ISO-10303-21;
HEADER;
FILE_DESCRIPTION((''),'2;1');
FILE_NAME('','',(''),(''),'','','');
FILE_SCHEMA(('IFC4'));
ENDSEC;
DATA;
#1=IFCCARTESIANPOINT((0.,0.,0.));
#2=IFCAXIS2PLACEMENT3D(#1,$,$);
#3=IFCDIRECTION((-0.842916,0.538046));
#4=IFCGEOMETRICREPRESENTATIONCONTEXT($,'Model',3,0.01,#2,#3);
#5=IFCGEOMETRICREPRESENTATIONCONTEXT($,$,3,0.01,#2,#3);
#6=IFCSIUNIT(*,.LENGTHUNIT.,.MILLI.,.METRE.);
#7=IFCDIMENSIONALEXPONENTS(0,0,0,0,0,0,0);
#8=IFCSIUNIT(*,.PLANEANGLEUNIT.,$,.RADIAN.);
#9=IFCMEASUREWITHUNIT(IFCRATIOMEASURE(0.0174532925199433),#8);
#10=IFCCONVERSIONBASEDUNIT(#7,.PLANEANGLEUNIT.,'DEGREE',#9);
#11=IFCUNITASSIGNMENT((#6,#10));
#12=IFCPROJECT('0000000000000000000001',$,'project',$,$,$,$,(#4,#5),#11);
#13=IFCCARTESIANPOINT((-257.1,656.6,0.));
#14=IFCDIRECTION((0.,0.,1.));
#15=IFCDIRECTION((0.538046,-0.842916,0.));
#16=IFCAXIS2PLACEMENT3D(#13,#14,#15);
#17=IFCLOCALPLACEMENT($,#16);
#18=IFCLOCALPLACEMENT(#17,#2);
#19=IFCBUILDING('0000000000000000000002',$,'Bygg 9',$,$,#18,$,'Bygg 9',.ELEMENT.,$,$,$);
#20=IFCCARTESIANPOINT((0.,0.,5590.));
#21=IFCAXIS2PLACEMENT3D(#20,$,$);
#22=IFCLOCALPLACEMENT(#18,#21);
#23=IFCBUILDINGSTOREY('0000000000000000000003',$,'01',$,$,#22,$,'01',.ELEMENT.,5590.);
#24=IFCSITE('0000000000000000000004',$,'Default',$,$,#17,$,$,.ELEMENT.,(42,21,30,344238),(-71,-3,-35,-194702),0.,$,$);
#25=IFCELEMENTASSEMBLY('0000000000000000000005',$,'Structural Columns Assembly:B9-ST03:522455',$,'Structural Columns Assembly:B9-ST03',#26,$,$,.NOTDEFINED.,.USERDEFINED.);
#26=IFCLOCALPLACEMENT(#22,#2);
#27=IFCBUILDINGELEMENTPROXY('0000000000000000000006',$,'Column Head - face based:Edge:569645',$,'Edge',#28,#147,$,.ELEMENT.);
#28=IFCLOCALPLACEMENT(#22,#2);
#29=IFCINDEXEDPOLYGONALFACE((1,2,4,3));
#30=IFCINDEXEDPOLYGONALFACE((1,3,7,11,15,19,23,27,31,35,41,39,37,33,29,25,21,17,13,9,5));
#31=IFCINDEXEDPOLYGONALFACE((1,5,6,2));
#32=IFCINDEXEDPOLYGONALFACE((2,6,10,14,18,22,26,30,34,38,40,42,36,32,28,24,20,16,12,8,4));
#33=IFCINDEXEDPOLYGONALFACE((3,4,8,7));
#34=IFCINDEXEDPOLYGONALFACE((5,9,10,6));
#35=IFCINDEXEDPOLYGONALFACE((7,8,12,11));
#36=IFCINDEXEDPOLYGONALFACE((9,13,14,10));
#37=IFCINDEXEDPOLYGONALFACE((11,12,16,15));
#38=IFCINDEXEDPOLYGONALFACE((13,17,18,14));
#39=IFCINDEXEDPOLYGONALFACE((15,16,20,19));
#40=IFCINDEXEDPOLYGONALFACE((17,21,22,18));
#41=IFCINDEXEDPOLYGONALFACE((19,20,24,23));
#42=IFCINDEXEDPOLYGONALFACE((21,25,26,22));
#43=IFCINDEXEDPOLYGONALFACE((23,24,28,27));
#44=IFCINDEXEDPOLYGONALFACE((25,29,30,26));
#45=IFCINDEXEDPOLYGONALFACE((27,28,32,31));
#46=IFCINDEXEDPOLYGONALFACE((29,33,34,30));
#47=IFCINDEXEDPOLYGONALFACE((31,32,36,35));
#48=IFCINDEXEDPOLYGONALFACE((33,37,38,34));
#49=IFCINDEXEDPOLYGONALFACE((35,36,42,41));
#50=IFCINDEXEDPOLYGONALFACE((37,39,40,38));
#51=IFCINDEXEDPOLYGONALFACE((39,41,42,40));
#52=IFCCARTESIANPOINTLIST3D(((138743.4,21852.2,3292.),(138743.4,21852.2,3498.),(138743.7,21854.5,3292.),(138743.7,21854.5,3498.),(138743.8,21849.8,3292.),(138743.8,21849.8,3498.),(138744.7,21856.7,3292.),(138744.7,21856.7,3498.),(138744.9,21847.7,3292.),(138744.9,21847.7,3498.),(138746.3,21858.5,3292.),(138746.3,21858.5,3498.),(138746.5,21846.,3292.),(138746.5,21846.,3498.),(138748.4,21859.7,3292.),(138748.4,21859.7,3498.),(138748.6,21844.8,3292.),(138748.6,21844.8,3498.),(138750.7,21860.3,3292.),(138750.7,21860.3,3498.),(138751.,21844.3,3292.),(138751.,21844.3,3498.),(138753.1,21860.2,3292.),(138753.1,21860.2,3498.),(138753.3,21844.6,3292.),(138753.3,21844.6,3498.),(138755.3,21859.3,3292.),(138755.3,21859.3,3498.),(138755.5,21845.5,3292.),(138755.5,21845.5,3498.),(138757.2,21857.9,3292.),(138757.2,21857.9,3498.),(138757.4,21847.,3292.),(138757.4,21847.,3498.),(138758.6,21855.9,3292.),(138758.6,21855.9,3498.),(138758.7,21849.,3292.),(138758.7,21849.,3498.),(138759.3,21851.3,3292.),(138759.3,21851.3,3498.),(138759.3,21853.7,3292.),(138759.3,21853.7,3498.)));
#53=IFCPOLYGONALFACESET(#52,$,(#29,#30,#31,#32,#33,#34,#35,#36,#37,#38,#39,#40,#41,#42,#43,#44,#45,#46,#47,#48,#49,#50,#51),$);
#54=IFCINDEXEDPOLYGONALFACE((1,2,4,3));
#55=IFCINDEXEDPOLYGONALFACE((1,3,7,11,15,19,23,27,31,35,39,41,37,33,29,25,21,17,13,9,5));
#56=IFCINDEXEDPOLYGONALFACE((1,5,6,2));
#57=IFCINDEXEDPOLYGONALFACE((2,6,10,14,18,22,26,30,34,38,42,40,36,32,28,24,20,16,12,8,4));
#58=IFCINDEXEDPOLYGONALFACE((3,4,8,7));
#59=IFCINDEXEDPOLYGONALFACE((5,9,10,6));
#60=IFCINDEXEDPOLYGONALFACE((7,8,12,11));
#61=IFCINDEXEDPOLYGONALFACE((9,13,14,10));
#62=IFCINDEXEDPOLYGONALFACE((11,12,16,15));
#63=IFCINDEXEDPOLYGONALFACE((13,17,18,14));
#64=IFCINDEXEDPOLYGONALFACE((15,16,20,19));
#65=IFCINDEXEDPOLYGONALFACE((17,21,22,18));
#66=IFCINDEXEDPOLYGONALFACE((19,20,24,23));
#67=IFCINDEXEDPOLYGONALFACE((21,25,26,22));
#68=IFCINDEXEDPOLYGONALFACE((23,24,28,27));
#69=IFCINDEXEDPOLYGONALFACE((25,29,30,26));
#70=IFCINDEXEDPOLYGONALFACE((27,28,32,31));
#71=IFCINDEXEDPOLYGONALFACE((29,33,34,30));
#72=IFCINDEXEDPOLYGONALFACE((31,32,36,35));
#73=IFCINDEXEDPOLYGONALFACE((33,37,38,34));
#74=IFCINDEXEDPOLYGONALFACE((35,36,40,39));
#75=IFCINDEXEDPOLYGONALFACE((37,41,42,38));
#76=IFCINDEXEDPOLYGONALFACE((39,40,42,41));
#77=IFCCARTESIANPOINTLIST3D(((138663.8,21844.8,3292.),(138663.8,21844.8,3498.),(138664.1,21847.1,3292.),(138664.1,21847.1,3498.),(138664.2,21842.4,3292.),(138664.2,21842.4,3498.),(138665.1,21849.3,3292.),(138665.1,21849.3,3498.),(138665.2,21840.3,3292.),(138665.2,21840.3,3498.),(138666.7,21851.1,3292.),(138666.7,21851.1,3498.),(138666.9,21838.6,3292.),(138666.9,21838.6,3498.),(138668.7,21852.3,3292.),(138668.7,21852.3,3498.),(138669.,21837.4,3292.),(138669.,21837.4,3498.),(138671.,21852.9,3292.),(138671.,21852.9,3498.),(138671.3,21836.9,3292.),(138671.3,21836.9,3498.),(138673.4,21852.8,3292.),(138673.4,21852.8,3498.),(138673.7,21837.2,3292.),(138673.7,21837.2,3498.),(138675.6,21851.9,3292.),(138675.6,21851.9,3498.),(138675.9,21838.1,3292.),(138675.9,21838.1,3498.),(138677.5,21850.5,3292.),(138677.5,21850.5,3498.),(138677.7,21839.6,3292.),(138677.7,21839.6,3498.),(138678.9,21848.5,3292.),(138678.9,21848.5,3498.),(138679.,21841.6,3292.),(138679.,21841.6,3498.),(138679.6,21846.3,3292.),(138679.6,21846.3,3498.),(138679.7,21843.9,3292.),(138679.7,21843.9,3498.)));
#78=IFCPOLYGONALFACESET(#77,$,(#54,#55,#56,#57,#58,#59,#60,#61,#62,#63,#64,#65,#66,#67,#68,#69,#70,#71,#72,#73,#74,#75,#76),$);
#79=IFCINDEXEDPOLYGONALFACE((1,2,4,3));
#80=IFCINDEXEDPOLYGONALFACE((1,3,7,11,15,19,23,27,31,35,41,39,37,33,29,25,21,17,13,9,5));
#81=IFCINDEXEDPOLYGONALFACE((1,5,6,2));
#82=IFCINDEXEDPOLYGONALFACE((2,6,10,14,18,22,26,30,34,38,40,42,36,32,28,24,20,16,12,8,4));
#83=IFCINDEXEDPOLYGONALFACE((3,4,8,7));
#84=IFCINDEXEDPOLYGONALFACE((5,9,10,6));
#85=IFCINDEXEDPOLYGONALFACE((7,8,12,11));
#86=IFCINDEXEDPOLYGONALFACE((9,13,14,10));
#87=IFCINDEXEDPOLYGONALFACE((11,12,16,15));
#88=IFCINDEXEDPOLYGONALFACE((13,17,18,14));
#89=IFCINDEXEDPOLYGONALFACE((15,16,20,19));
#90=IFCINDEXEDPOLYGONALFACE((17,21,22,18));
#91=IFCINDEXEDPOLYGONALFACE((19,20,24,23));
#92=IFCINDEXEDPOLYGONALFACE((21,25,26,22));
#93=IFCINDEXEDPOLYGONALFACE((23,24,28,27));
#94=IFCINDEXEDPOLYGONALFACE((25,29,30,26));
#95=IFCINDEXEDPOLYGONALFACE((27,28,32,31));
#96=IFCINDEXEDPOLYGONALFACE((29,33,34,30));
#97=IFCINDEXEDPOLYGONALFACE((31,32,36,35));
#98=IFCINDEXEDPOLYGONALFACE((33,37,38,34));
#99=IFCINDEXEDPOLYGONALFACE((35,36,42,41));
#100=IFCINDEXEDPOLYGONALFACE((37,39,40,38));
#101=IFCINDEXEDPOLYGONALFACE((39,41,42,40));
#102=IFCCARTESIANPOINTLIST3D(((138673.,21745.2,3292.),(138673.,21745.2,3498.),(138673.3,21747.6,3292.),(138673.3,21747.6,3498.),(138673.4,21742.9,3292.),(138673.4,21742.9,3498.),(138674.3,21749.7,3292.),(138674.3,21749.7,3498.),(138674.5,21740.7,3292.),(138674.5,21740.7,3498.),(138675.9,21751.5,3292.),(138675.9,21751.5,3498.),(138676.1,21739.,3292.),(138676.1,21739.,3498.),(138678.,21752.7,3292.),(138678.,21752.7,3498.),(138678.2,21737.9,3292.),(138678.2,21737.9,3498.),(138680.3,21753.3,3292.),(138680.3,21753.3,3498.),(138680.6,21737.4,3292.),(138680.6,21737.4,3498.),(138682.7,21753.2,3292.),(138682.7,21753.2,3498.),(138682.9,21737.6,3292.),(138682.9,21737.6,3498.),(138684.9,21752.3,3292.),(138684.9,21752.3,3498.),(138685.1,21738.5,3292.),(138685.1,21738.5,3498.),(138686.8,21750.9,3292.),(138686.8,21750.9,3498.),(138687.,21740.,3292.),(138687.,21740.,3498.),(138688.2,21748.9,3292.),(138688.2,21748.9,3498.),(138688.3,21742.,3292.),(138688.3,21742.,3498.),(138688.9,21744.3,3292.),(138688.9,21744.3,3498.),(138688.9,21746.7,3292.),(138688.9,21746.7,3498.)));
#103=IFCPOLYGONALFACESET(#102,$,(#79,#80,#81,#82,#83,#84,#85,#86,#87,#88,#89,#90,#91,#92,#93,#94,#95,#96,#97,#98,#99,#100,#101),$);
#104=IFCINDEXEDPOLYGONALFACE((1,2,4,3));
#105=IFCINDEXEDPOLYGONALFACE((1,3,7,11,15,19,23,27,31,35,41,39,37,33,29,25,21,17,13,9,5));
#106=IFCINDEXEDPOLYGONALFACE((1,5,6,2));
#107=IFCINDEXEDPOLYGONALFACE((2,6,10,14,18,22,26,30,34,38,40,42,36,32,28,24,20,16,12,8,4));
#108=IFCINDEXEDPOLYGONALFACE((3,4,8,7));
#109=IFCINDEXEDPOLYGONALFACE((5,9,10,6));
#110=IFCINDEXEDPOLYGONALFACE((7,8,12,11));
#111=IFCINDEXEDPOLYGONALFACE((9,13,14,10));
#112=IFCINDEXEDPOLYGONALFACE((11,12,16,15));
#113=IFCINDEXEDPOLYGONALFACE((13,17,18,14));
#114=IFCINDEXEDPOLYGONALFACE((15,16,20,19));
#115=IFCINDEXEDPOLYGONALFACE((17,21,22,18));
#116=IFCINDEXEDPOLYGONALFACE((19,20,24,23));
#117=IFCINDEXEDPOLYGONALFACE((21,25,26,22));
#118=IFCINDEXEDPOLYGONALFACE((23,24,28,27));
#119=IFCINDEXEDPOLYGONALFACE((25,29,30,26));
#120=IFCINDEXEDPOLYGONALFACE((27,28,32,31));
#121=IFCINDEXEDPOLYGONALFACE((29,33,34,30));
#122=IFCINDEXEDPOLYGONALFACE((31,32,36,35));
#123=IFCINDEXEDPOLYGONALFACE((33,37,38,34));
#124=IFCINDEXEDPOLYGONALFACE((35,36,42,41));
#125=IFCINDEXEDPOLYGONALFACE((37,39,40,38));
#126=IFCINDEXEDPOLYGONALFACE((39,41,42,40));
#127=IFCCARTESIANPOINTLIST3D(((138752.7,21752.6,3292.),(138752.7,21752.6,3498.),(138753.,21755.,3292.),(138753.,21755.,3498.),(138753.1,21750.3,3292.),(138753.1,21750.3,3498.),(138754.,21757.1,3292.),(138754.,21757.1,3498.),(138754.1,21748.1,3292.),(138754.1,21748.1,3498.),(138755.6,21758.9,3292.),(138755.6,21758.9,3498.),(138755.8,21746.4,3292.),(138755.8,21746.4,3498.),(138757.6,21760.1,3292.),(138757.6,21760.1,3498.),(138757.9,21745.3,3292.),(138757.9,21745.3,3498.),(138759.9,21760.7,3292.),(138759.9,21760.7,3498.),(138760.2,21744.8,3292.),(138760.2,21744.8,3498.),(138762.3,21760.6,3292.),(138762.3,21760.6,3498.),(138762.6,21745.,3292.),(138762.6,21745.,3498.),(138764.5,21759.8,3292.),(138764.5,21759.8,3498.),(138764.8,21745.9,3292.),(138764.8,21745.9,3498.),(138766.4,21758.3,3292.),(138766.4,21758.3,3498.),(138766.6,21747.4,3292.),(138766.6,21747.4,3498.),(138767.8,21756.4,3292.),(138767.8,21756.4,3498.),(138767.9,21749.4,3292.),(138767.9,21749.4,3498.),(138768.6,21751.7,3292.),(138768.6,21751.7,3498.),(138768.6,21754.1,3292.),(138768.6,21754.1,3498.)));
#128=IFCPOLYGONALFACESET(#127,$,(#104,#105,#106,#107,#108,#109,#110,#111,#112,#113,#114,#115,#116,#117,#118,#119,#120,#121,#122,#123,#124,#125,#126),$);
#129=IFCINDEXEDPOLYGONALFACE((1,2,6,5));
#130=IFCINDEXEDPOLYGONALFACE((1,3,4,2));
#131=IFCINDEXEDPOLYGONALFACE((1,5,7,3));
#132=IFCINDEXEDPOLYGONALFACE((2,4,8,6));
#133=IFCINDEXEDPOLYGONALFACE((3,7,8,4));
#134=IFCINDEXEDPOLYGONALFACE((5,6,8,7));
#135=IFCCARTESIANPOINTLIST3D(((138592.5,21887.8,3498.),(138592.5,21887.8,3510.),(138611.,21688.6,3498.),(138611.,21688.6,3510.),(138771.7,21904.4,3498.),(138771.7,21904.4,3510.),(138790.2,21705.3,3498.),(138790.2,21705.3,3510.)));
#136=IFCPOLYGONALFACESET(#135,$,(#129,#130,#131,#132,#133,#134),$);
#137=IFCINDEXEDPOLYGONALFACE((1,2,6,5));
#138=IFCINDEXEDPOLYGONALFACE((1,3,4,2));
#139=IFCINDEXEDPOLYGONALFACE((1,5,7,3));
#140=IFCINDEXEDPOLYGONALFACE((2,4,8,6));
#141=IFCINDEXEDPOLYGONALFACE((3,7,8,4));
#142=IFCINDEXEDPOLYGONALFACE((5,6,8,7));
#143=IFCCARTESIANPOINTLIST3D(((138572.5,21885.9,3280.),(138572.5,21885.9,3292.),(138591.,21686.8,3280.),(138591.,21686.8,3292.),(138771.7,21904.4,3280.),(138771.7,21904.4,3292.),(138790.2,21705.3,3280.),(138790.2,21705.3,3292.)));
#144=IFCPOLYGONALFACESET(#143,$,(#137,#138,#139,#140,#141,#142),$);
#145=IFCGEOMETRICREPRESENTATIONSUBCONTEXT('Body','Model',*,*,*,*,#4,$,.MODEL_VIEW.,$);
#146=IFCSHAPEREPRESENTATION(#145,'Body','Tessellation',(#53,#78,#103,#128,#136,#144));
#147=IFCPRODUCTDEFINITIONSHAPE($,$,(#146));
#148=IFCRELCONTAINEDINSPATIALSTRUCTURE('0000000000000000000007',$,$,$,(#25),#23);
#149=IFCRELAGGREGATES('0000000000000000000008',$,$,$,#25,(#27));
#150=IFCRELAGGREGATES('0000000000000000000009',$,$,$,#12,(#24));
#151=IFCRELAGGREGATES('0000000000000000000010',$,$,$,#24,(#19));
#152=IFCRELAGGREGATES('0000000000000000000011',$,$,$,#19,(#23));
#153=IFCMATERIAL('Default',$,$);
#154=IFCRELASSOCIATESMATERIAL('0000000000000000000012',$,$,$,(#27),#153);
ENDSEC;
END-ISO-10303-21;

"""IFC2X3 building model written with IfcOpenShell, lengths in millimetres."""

from ifc_helpers import new_model, entity, si_unit, converted_unit, direction, frame, frame_2d, origin, origin_2d_with_axis, place, context, subcontext, project, spatial, rectangle, circle, extrude, source, transform, mapped, material, element, aggregate, save


model = new_model("IFC2X3")

# Units and contexts
model_context = context("Model", 3, precision=0.01, world=origin(), true_north=direction((-0.842916, 0.538046)))
context_of_model = context(None, 3, precision=0.01, world=origin(), true_north=direction((-0.842916, 0.538046)))
body_context = subcontext(model_context, "Body", "Model", "MODEL_VIEW")
ifc_project = project(units=[si_unit("LENGTHUNIT", "METRE", prefix="MILLI"), converted_unit("PLANEANGLEUNIT", "DEGREE", entity("IfcRatioMeasure", 0.0174532925199433), si_unit("PLANEANGLEUNIT", "RADIAN"), dimensions=[0, 0, 0, 0, 0, 0, 0])], contexts=[model_context, context_of_model])

# Site, building, storey
site_placement = place(None, frame((-257.1, 656.6, 0.0), z_axis=(0.0, 0.0, 1.0), x_axis=(0.538046, -0.842916, 0.0)))
site = spatial("IfcSite", under=ifc_project, at=site_placement, Name="Default", CompositionType="ELEMENT", RefLatitude=(42, 21, 30, 344238), RefLongitude=(-71, -3, -35, -194702), RefElevation=0.0)
building_placement = place(site_placement, origin())
building = spatial("IfcBuilding", under=site, at=building_placement, Name="Bygg 9", LongName="Bygg 9", CompositionType="ELEMENT")
storey_placement = place(building_placement, frame((0.0, 0.0, 5590.0)))
storey = spatial("IfcBuildingStorey", under=building, at=storey_placement, Name="01", LongName="01", CompositionType="ELEMENT", Elevation=5590.0)

# Element assembly, building element proxy
ifc_material_1 = material(Name="Default")
shared_shape_1 = source(origin(), body_context, "Body", "SweptSolid", [
    extrude(circle(Radius=8.0, at=frame_2d((0.0, 0.0), x_axis=(1.0, 0.0))), frame((50.0, -135.0, 12.0)), (0.0, 0.0, 1.0), 206.0),
    extrude(circle(Radius=8.0, at=frame_2d((0.0, 0.0), x_axis=(1.0, 0.0))), frame((50.0, -55.0, 12.0)), (0.0, 0.0, 1.0), 206.0),
    extrude(circle(Radius=8.0, at=frame_2d((0.0, 0.0), x_axis=(1.0, 0.0))), frame((-50.0, -55.0, 12.0)), (0.0, 0.0, 1.0), 206.0),
    extrude(circle(Radius=8.0, at=frame_2d((0.0, 0.0), x_axis=(1.0, 0.0))), frame((-50.0, -135.0, 12.0)), (0.0, 0.0, 1.0), 206.0),
    extrude(rectangle(XDim=200.0, YDim=180.0, at=origin_2d_with_axis()), frame((0.0, -70.0, 218.0), z_axis=(0.0, 0.0, 1.0), x_axis=(-1.0, 0.0, 0.0)), (0.0, 0.0, 1.0), 12.0),
    extrude(rectangle(XDim=200.0, YDim=200.0, at=origin_2d_with_axis()), frame((0.0, -60.0, 0.0), z_axis=(0.0, 0.0, 1.0), x_axis=(0.0, 1.0, 0.0)), (0.0, 0.0, 1.0), 12.0),
])
assembly_1_placement = place(storey_placement, origin())
assembly_1 = element("IfcElementAssembly", 1, at=assembly_1_placement, inside=storey, Name="Structural Columns Assembly:B9-ST03:522455", ObjectType="Structural Columns Assembly:B9-ST03", AssemblyPlace="NOTDEFINED", PredefinedType="USERDEFINED")
proxy_1_placement = place(assembly_1_placement, frame((138621.6, 21790.0, 3280.0), z_axis=(0.0, 0.0, 1.0), x_axis=(-0.092535, 0.995709, 0.0)))
proxy_1 = element("IfcBuildingElementProxy", 2, at=proxy_1_placement, material=ifc_material_1, Name="Column Head - face based:Edge:569645", ObjectType="Edge", CompositionType="ELEMENT", context=body_context, shape_type="MappedRepresentation", body=[
    mapped(shared_shape_1, transform((0.0, 0.0, 0.0), scale=1.0)),
])
aggregate(assembly_1, [proxy_1])

save(model, "model.ifc")
